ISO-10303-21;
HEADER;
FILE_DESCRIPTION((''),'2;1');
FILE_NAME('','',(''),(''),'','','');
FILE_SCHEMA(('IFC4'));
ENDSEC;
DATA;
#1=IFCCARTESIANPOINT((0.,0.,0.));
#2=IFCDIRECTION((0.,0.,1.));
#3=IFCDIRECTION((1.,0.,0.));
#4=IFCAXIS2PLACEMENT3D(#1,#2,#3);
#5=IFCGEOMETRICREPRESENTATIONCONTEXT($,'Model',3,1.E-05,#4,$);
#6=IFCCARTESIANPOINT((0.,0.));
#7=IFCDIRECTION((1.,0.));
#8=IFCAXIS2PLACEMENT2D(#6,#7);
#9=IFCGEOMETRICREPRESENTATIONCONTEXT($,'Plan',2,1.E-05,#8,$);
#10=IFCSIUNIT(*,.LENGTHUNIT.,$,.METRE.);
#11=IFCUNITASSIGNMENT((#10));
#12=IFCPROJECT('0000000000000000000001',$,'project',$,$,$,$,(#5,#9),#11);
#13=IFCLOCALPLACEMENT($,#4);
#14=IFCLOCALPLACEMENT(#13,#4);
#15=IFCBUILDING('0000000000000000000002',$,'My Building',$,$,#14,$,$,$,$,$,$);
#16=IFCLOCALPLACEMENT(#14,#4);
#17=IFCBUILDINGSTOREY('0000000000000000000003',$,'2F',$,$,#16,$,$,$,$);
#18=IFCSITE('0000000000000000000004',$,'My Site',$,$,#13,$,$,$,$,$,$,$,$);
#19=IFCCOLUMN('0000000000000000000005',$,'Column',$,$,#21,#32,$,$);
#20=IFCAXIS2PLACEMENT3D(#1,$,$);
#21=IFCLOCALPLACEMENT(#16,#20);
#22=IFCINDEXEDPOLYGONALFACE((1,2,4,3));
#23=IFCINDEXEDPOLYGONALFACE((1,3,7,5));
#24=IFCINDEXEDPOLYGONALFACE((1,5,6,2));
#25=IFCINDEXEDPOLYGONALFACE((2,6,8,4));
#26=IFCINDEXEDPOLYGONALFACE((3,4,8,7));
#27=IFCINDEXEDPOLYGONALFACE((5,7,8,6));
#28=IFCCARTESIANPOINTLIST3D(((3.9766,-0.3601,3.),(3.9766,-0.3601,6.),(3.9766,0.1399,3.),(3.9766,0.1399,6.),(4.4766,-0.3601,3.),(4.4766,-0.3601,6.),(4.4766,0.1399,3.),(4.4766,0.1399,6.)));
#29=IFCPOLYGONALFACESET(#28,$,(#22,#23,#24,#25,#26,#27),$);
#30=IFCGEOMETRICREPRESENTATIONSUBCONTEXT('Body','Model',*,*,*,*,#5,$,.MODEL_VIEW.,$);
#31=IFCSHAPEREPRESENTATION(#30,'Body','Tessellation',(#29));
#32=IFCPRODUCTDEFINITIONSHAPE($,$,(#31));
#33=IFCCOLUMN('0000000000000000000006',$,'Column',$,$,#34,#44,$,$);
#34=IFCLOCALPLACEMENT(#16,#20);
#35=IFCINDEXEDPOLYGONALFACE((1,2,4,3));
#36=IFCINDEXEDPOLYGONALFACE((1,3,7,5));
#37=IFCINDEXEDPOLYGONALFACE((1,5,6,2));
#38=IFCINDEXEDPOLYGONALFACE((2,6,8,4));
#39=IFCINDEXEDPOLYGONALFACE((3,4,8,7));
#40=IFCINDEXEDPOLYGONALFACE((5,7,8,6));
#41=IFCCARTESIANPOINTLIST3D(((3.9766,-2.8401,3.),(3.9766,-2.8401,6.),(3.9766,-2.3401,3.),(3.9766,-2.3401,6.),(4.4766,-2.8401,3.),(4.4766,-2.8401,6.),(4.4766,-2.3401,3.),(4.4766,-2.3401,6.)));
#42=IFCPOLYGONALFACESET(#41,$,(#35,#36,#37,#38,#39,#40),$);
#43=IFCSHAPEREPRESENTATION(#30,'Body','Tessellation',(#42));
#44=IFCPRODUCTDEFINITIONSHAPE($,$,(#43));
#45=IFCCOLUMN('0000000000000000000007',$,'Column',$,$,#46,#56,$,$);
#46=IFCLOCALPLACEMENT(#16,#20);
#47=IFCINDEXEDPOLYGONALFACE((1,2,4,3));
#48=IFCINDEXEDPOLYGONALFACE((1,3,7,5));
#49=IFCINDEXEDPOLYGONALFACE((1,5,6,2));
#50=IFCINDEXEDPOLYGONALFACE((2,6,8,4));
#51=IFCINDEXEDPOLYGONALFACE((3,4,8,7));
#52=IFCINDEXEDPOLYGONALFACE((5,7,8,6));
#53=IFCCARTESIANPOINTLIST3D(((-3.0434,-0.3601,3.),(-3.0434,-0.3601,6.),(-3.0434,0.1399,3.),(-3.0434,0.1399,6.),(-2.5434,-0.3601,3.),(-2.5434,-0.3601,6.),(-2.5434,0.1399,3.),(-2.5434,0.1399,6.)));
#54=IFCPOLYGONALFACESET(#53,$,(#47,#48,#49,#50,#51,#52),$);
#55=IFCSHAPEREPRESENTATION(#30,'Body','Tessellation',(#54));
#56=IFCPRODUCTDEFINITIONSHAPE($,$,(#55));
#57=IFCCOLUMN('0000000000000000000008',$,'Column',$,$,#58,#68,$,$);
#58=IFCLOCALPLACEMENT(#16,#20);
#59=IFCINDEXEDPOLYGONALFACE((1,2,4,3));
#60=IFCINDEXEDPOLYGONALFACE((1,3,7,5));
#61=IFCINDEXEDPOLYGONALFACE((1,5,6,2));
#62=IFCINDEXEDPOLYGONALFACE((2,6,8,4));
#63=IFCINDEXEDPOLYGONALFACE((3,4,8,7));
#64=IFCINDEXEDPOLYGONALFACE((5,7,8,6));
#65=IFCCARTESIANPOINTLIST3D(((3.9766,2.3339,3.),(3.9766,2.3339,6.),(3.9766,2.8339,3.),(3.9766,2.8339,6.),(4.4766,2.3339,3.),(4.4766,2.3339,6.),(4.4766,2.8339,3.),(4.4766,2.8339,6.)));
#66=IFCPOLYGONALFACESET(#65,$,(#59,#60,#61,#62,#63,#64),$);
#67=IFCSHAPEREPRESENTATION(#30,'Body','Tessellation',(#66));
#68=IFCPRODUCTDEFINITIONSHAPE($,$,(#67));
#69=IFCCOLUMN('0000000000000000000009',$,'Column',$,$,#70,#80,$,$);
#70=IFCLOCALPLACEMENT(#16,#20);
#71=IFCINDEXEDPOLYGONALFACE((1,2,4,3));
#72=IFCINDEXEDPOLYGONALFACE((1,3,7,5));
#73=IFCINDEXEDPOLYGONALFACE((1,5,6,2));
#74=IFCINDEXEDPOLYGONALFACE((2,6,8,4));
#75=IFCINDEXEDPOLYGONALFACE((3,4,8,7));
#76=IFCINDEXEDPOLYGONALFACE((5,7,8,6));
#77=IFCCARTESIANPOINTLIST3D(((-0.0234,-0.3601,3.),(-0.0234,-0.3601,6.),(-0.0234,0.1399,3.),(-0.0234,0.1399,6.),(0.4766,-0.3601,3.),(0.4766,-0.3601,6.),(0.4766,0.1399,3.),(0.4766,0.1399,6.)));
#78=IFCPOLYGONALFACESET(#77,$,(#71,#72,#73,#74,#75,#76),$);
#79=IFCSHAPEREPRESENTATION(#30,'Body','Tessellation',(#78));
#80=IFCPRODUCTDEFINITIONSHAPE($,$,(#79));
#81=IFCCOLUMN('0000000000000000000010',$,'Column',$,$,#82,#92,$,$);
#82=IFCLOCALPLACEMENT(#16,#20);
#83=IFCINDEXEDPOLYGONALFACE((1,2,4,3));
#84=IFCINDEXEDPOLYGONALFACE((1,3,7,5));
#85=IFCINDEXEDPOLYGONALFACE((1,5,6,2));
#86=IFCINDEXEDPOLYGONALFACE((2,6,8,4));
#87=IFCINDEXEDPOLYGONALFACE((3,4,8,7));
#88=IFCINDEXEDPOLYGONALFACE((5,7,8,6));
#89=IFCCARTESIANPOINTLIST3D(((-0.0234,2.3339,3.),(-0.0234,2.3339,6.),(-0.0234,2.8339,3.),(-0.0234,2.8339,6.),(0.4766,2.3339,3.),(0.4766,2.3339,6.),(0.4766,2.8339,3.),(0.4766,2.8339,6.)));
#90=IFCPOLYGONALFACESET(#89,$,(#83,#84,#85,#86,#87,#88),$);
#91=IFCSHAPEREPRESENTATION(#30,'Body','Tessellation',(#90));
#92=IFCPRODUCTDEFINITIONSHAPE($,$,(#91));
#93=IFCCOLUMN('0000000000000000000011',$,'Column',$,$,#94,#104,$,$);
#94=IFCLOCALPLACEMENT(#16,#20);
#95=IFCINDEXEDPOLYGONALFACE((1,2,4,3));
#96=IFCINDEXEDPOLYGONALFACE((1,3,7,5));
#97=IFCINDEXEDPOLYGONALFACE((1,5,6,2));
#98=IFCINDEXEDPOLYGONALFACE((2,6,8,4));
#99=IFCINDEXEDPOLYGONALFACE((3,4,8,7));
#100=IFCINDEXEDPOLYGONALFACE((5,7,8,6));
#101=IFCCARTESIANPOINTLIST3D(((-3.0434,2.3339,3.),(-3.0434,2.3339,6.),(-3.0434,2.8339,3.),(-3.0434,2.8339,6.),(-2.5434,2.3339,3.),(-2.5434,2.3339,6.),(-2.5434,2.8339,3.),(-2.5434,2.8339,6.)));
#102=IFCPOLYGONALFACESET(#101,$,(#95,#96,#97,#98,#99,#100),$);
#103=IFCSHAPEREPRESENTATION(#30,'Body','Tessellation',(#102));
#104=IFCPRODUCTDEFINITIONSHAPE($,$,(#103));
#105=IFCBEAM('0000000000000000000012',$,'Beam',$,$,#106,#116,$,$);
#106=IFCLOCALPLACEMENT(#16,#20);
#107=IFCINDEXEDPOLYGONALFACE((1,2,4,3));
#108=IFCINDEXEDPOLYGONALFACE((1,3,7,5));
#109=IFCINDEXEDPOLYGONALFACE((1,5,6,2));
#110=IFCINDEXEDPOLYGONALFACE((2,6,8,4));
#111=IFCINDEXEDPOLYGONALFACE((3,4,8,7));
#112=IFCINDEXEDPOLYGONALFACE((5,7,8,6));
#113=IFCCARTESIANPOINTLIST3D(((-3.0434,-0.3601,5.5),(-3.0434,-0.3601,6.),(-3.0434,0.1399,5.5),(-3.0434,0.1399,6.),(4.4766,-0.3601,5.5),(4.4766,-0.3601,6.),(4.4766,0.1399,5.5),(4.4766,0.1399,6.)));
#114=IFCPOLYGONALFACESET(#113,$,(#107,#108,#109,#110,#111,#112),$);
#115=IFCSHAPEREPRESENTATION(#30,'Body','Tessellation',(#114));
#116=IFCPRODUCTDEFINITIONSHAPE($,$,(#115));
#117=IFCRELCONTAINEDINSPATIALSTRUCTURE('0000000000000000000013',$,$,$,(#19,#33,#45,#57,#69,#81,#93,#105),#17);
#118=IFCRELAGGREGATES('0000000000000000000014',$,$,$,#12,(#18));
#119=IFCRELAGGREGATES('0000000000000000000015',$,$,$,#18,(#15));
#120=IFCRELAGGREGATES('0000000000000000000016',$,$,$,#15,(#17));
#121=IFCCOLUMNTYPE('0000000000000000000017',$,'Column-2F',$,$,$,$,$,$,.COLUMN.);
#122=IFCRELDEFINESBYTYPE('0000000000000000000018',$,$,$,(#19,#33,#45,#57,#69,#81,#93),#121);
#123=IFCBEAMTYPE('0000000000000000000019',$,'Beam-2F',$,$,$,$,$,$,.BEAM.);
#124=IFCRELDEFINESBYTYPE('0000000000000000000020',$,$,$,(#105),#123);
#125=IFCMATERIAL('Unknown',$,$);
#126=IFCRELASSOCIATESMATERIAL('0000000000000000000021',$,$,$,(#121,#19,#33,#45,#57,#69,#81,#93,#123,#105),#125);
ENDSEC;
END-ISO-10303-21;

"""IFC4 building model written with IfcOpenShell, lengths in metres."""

from ifc_helpers import new_model, si_unit, frame, origin_with_axes, origin_2d_with_axis, place, context, subcontext, project, spatial, rectangle, extrude, material, material_profile, profile_set, profile_usage, type_object, element, save


model = new_model("IFC4")

# Units and contexts
model_context = context("Model", 3, precision=1e-05, world=origin_with_axes())
plan_context = context("Plan", 2, precision=1e-05, world=origin_2d_with_axis())
body_context_1 = subcontext(model_context, "Body", "Model", "MODEL_VIEW")
ifc_project = project(units=[si_unit("LENGTHUNIT", "METRE")], contexts=[model_context, plan_context])

# Site, building, storey
site_placement = place(None, origin_with_axes())
site = spatial("IfcSite", under=ifc_project, at=site_placement, Name="My Site")
building_placement = place(site_placement, origin_with_axes())
building = spatial("IfcBuilding", under=site, at=building_placement, Name="My Building")
storey_placement = place(building_placement, origin_with_axes())
storey = spatial("IfcBuildingStorey", under=building, at=storey_placement, Name="2F")

# Columns
ifc_material = material(Name="Unknown")
ifc_material_profile_1 = material_profile(ifc_material, rectangle(XDim=0.5, YDim=0.5))
ifc_profile_set_1 = profile_set([ifc_material_profile_1])
ifc_profile_usage_1 = profile_usage(ifc_profile_set_1, cardinal=7)
column_type = type_object("IfcColumnType", Name="Column-2F", PredefinedType="COLUMN", material=ifc_profile_set_1)
column_1_placement = place(storey_placement, frame((4.4766, 0.1399, 3.0), z_axis=(0.0, 0.0, 1.0), x_axis=(1.0, 0.0, 0.0)))
element("IfcColumn", 1, at=column_1_placement, inside=storey, type_object=column_type, material=ifc_profile_usage_1, Name="Column", context=body_context_1, shape_type="SweptSolid", body=[
    extrude(rectangle(XDim=0.5, YDim=0.5), frame((-0.25, -0.25, 0.0), z_axis=(0.0, 0.0, 1.0), x_axis=(1.0, 0.0, 0.0)), (0.0, 0.0, 1.0), 3.0),
])
ifc_profile_usage_2 = profile_usage(ifc_profile_set_1, cardinal=7)
column_2_placement = place(storey_placement, frame((4.4766, -2.3401, 3.0), z_axis=(0.0, 0.0, 1.0), x_axis=(1.0, 0.0, 0.0)))
element("IfcColumn", 2, at=column_2_placement, inside=storey, type_object=column_type, material=ifc_profile_usage_2, Name="Column", context=body_context_1, shape_type="SweptSolid", body=[
    extrude(rectangle(XDim=0.5, YDim=0.5), frame((-0.25, -0.25, 0.0), z_axis=(0.0, 0.0, 1.0), x_axis=(1.0, 0.0, 0.0)), (0.0, 0.0, 1.0), 3.0),
])
ifc_profile_usage_3 = profile_usage(ifc_profile_set_1, cardinal=7)
column_3_placement = place(storey_placement, frame((-2.5434, 0.1399, 3.0), z_axis=(0.0, 0.0, 1.0), x_axis=(1.0, 0.0, 0.0)))
element("IfcColumn", 3, at=column_3_placement, inside=storey, type_object=column_type, material=ifc_profile_usage_3, Name="Column", context=body_context_1, shape_type="SweptSolid", body=[
    extrude(rectangle(XDim=0.5, YDim=0.5), frame((-0.25, -0.25, 0.0), z_axis=(0.0, 0.0, 1.0), x_axis=(1.0, 0.0, 0.0)), (0.0, 0.0, 1.0), 3.0),
])
ifc_profile_usage_4 = profile_usage(ifc_profile_set_1, cardinal=7)
column_4_placement = place(storey_placement, frame((4.4766, 2.8339, 3.0), z_axis=(0.0, 0.0, 1.0), x_axis=(1.0, 0.0, 0.0)))
element("IfcColumn", 4, at=column_4_placement, inside=storey, type_object=column_type, material=ifc_profile_usage_4, Name="Column", context=body_context_1, shape_type="SweptSolid", body=[
    extrude(rectangle(XDim=0.5, YDim=0.5), frame((-0.25, -0.25, 0.0), z_axis=(0.0, 0.0, 1.0), x_axis=(1.0, 0.0, 0.0)), (0.0, 0.0, 1.0), 3.0),
])
ifc_profile_usage_5 = profile_usage(ifc_profile_set_1, cardinal=7)
column_5_placement = place(storey_placement, frame((0.4766, 0.1399, 3.0), z_axis=(0.0, 0.0, 1.0), x_axis=(1.0, 0.0, 0.0)))
element("IfcColumn", 5, at=column_5_placement, inside=storey, type_object=column_type, material=ifc_profile_usage_5, Name="Column", context=body_context_1, shape_type="SweptSolid", body=[
    extrude(rectangle(XDim=0.5, YDim=0.5), frame((-0.25, -0.25, 0.0), z_axis=(0.0, 0.0, 1.0), x_axis=(1.0, 0.0, 0.0)), (0.0, 0.0, 1.0), 3.0),
])
ifc_profile_usage_6 = profile_usage(ifc_profile_set_1, cardinal=7)
column_6_placement = place(storey_placement, frame((0.4766, 2.8339, 3.0), z_axis=(0.0, 0.0, 1.0), x_axis=(1.0, 0.0, 0.0)))
element("IfcColumn", 6, at=column_6_placement, inside=storey, type_object=column_type, material=ifc_profile_usage_6, Name="Column", context=body_context_1, shape_type="SweptSolid", body=[
    extrude(rectangle(XDim=0.5, YDim=0.5), frame((-0.25, -0.25, 0.0), z_axis=(0.0, 0.0, 1.0), x_axis=(1.0, 0.0, 0.0)), (0.0, 0.0, 1.0), 3.0),
])
ifc_profile_usage_7 = profile_usage(ifc_profile_set_1, cardinal=7)
column_7_placement = place(storey_placement, frame((-2.5434, 2.8339, 3.0), z_axis=(0.0, 0.0, 1.0), x_axis=(1.0, 0.0, 0.0)))
element("IfcColumn", 7, at=column_7_placement, inside=storey, type_object=column_type, material=ifc_profile_usage_7, Name="Column", context=body_context_1, shape_type="SweptSolid", body=[
    extrude(rectangle(XDim=0.5, YDim=0.5), frame((-0.25, -0.25, 0.0), z_axis=(0.0, 0.0, 1.0), x_axis=(1.0, 0.0, 0.0)), (0.0, 0.0, 1.0), 3.0),
])

# Beam
ifc_material_profile_2 = material_profile(ifc_material, rectangle(XDim=0.5, YDim=0.5))
ifc_profile_set_2 = profile_set([ifc_material_profile_2])
ifc_profile_usage_8 = profile_usage(ifc_profile_set_2, cardinal=7)
beam_type = type_object("IfcBeamType", Name="Beam-2F", PredefinedType="BEAM", material=ifc_profile_set_2)
beam_placement = place(storey_placement, frame((-3.0434, 0.1399, 6.0), z_axis=(1.0, -0.000001, 0.000001), x_axis=(0.000001, 1.0, 0.0)))
element("IfcBeam", 8, at=beam_placement, inside=storey, type_object=beam_type, material=ifc_profile_usage_8, Name="Beam", context=body_context_1, shape_type="SweptSolid", body=[
    extrude(rectangle(XDim=0.5, YDim=0.5), frame((-0.25, -0.25, 0.0), z_axis=(0.0, 0.0, 1.0), x_axis=(1.0, 0.0, 0.0)), (0.0, 0.0, 1.0), 7.52),
])

save(model, "model.ifc")
